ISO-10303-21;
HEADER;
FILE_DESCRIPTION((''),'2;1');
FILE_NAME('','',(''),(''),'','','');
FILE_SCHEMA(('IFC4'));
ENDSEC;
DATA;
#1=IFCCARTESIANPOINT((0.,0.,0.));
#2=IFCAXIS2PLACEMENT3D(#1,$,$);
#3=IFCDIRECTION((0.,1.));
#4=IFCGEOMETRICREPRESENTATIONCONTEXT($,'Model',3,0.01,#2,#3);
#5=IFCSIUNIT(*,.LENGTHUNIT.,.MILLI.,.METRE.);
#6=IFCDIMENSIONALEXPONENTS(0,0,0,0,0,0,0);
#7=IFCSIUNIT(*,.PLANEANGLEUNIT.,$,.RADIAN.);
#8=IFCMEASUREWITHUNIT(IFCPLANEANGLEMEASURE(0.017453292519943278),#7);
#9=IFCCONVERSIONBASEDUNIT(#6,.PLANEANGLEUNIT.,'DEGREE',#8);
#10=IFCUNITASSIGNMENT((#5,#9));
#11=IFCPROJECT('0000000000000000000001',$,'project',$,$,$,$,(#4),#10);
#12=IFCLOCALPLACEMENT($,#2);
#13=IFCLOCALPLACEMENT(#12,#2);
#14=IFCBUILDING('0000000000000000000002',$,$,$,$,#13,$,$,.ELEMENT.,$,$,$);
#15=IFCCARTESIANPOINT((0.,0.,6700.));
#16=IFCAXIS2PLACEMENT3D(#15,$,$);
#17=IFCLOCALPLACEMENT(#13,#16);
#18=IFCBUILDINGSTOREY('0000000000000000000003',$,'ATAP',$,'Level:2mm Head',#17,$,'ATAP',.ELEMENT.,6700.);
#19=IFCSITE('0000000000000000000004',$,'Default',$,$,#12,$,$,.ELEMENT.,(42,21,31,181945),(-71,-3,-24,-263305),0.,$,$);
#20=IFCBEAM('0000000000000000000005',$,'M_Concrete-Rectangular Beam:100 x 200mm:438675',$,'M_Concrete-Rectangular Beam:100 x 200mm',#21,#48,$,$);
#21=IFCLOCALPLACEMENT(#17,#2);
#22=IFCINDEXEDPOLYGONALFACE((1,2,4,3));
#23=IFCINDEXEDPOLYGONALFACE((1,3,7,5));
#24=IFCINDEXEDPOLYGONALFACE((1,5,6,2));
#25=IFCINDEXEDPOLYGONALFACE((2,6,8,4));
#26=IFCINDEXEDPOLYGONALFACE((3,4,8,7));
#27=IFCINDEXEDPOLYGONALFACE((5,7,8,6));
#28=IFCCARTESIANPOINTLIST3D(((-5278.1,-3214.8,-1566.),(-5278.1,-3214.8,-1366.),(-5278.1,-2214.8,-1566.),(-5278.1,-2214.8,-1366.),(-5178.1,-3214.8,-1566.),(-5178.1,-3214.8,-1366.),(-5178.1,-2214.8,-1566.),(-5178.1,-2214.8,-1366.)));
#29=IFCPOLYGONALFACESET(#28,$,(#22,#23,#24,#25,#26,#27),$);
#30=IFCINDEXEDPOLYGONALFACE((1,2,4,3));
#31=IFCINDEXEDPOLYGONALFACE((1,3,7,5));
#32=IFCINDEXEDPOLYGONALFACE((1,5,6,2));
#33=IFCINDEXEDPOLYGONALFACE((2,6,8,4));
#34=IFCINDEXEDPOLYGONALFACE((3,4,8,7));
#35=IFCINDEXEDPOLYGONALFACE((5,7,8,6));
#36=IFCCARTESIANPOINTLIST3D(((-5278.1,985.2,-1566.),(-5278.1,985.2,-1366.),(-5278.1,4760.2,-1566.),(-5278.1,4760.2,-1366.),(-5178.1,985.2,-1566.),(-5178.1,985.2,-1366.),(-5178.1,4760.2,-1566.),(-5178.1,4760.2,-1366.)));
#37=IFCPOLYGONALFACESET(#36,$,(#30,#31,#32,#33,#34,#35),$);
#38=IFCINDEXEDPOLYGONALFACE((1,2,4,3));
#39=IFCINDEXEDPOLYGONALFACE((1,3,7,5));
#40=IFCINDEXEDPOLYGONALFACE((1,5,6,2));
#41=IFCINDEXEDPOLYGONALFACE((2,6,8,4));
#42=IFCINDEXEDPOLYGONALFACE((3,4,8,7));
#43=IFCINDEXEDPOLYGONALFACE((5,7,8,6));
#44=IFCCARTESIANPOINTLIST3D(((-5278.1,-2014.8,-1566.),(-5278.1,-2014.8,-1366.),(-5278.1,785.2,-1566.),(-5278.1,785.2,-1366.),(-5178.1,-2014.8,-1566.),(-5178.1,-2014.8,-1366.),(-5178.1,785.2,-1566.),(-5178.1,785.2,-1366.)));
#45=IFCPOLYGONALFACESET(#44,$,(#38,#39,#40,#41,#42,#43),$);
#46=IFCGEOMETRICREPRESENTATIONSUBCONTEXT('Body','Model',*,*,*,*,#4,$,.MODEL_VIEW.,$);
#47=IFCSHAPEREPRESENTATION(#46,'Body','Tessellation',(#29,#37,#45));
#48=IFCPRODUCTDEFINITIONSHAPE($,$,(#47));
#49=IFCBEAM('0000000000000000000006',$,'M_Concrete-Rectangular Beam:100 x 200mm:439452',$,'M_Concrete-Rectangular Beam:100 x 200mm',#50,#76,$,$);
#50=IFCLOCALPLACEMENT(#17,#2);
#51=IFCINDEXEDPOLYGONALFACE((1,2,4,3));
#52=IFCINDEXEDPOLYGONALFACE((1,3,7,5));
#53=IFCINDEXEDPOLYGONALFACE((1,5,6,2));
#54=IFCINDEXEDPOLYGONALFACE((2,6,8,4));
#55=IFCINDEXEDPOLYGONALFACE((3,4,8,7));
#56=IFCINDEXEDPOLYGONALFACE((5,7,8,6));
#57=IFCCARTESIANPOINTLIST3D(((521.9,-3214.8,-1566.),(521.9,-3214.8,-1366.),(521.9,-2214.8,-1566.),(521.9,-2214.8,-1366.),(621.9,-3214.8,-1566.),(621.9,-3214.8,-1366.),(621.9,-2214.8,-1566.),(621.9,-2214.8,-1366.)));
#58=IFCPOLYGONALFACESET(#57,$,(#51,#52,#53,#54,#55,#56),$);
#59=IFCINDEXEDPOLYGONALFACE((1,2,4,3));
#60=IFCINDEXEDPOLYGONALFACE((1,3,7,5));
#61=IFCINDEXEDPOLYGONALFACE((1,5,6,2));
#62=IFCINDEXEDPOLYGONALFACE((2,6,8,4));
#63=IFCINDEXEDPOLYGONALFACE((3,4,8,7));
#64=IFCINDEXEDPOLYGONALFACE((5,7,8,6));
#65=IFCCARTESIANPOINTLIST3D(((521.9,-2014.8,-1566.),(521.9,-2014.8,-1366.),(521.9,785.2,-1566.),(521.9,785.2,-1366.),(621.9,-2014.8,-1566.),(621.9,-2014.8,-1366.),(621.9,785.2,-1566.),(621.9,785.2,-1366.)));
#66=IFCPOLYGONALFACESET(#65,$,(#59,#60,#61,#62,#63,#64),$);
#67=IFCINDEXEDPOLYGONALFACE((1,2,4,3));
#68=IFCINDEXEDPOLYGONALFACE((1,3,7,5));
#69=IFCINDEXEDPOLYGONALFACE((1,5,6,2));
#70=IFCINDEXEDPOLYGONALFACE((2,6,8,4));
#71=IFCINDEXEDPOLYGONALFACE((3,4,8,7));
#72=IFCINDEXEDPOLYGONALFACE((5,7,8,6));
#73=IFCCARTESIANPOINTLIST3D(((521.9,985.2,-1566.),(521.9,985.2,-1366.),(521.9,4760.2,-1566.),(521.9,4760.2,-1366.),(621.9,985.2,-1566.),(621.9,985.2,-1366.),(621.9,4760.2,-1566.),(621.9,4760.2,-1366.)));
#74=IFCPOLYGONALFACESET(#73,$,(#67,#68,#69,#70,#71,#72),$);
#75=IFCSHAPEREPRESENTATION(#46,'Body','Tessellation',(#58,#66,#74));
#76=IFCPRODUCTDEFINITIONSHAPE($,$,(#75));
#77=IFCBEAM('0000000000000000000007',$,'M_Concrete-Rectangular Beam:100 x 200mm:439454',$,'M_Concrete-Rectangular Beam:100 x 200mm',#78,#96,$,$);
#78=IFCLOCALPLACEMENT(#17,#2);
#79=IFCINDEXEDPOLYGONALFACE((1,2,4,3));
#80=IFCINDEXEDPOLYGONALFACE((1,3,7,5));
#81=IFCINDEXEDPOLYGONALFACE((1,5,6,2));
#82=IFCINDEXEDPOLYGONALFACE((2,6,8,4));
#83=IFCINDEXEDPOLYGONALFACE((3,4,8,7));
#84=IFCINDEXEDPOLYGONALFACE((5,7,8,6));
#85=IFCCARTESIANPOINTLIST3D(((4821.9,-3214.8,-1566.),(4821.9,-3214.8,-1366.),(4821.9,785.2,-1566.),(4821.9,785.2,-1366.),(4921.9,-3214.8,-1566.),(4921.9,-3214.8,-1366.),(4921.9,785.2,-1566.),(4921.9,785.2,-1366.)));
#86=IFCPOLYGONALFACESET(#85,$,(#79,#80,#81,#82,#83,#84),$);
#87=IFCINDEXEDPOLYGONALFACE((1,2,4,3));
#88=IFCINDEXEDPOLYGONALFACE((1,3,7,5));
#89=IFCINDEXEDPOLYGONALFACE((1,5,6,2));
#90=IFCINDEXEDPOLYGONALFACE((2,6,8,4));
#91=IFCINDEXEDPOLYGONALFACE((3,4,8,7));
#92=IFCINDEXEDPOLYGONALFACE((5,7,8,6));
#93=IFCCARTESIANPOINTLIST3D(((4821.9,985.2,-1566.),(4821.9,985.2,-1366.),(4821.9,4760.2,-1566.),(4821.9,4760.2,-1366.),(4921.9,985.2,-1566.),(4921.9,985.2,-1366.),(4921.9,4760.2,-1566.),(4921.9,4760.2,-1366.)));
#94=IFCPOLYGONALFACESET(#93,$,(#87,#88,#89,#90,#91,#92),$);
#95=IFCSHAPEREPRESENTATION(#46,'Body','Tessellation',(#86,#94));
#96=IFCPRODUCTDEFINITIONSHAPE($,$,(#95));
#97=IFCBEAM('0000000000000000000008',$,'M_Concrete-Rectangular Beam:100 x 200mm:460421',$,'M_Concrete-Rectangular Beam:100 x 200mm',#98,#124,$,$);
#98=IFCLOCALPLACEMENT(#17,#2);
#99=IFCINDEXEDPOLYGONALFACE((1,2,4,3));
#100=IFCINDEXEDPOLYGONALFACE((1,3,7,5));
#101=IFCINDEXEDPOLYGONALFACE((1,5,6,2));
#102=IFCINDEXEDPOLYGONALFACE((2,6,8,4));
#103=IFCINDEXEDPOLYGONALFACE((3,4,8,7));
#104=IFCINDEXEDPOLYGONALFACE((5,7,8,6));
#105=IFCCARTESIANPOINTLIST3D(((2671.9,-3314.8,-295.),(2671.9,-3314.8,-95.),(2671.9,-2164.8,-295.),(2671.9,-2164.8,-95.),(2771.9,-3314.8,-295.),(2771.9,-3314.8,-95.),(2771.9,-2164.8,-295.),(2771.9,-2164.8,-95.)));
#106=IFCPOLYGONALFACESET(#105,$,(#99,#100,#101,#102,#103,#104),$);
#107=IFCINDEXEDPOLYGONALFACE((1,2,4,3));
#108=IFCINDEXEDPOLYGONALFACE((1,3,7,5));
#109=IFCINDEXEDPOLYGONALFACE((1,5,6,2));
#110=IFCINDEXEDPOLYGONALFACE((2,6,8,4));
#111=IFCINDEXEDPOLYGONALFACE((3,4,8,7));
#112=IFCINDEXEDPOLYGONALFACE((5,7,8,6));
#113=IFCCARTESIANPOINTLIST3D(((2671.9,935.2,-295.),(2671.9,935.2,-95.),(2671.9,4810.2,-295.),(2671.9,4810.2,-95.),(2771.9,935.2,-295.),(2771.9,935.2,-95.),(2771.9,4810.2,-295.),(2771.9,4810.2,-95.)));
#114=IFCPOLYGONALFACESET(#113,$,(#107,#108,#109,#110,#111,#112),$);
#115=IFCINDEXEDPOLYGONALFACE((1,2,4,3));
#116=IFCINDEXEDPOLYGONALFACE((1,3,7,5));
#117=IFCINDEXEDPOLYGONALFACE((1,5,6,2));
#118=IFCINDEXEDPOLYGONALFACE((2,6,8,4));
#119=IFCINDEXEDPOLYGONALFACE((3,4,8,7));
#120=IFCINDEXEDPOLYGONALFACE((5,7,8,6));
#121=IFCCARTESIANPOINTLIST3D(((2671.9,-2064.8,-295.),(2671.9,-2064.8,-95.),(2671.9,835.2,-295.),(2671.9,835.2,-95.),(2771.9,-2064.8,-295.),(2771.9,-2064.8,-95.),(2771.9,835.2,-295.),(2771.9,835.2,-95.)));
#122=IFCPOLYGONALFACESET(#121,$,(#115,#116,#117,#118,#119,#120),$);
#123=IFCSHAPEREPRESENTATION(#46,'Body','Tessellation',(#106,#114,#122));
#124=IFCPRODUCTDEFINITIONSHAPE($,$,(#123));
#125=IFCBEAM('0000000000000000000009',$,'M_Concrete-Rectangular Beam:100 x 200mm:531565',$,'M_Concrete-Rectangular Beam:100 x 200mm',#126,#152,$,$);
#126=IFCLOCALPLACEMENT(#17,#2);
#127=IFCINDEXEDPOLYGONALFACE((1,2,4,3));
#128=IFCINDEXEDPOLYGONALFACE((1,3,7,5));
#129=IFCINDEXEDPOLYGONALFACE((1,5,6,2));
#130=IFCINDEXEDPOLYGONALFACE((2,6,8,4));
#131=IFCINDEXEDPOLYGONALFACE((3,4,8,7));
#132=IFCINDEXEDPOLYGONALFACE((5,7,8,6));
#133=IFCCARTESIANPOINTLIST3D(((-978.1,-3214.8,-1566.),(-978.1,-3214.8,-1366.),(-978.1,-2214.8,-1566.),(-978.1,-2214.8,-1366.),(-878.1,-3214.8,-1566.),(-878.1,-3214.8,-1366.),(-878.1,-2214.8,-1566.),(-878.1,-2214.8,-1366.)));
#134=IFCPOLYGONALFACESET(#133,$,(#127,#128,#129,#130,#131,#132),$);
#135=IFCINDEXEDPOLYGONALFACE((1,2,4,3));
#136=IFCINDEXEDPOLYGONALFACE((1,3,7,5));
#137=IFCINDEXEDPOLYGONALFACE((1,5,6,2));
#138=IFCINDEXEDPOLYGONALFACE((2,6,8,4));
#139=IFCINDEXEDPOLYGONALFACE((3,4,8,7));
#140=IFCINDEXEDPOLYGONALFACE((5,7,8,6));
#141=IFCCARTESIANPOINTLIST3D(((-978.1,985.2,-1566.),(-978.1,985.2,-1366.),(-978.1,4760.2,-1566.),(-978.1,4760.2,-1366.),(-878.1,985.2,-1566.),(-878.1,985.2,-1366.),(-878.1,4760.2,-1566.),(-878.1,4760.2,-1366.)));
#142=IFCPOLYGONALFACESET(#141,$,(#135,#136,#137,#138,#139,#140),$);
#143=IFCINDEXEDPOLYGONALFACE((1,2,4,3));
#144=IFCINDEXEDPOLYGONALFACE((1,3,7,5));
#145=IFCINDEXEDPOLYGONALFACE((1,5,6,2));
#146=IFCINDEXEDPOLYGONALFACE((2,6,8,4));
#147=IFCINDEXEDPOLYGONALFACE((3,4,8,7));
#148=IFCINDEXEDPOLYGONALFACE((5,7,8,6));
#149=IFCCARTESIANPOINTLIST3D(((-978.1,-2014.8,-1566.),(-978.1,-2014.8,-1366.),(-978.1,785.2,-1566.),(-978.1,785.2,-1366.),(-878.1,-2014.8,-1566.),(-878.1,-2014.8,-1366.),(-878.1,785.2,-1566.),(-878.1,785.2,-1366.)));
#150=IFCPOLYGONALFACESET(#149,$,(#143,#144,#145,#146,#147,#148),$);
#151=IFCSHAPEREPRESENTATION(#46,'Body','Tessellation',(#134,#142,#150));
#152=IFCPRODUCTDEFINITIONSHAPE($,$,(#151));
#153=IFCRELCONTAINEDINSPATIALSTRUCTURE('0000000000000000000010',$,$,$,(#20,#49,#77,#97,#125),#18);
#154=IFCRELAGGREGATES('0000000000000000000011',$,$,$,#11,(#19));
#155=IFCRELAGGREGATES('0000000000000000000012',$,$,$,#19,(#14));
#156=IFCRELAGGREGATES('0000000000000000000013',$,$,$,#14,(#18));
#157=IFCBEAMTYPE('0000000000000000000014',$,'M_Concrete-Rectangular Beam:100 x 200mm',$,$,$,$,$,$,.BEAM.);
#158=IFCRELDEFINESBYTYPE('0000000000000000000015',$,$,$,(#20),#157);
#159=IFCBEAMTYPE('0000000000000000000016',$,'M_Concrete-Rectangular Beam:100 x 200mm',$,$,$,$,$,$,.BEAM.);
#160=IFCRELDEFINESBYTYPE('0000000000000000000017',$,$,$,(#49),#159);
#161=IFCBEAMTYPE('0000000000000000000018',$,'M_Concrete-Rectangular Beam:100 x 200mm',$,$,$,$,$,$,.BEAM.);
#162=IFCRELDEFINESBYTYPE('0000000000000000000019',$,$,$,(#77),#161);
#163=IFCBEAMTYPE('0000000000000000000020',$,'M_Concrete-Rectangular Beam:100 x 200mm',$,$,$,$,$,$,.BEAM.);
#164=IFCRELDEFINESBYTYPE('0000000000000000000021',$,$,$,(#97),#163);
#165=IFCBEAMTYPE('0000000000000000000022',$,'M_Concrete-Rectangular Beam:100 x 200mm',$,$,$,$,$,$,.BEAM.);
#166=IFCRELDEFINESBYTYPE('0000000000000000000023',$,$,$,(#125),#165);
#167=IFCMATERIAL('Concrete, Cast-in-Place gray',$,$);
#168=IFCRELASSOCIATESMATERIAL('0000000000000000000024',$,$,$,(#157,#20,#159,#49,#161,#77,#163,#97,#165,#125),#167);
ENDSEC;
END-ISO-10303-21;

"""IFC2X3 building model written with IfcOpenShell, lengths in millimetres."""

from ifc_helpers import new_model, entity, si_unit, converted_unit, direction, frame, frame_2d, origin, place, context, subcontext, project, spatial, rectangle, extrude, source, transform, mapped, material, type_object, type_shapes, element, save


model = new_model("IFC2X3")

# Units and contexts
model_context = context("Model", 3, precision=0.01, world=origin(), true_north=direction((0.0, 1.0)))
body_context = subcontext(model_context, "Body", "Model", "MODEL_VIEW")
ifc_project = project(units=[si_unit("LENGTHUNIT", "METRE", prefix="MILLI"), converted_unit("PLANEANGLEUNIT", "DEGREE", entity("IfcPlaneAngleMeasure", 0.017453292519943278), si_unit("PLANEANGLEUNIT", "RADIAN"), dimensions=[0, 0, 0, 0, 0, 0, 0])], contexts=[model_context])

# Site, building, storey
site_placement = place(None, origin())
site = spatial("IfcSite", under=ifc_project, at=site_placement, Name="Default", CompositionType="ELEMENT", RefLatitude=(42, 21, 31, 181945), RefLongitude=(-71, -3, -24, -263305), RefElevation=0.0)
building_placement = place(site_placement, origin())
building = spatial("IfcBuilding", under=site, at=building_placement, CompositionType="ELEMENT")
storey_placement = place(building_placement, frame((0.0, 0.0, 6700.0)))
storey = spatial("IfcBuildingStorey", under=building, at=storey_placement, Name="ATAP", ObjectType="Level:2mm Head", LongName="ATAP", CompositionType="ELEMENT", Elevation=6700.0)

# Beams
ifc_material = material(Name="Concrete, Cast-in-Place gray")
beam_type_1 = type_object("IfcBeamType", Name="M_Concrete-Rectangular Beam:100 x 200mm", PredefinedType="BEAM", material=ifc_material)
shared_shape_1 = source(origin(), body_context, "Body", "SweptSolid", [
    extrude(rectangle(XDim=200.0, YDim=100.0, at=frame_2d((0.0, 0.0), x_axis=(0.0, 1.0))), frame((-5228.1, -2214.8, 5234.0), z_axis=(0.0, -1.0, 0.0), x_axis=(-1.0, 0.0, 0.0)), (0.0, 0.0, 1.0), 1000.0),
    extrude(rectangle(XDim=200.0, YDim=100.0, at=frame_2d((0.0, 0.0), x_axis=(0.0, 1.0))), frame((-5228.1, 4760.2, 5234.0), z_axis=(0.0, -1.0, 0.0), x_axis=(-1.0, 0.0, 0.0)), (0.0, 0.0, 1.0), 3775.0),
    extrude(rectangle(XDim=200.0, YDim=100.0, at=frame_2d((0.0, 0.0), x_axis=(0.0, 1.0))), frame((-5228.1, 785.2, 5234.0), z_axis=(0.0, -1.0, 0.0), x_axis=(-1.0, 0.0, 0.0)), (0.0, 0.0, 1.0), 2800.0),
])
type_shapes(beam_type_1, [shared_shape_1])
beam_1_placement = place(storey_placement, frame((0.0, 0.0, -6700.0)))
element("IfcBeam", 1, at=beam_1_placement, inside=storey, type_object=beam_type_1, material=ifc_material, Name="M_Concrete-Rectangular Beam:100 x 200mm:438675", ObjectType="M_Concrete-Rectangular Beam:100 x 200mm", context=body_context, shape_type="MappedRepresentation", body=[
    mapped(shared_shape_1, transform((0.0, 0.0, 0.0), scale=1.0)),
])
beam_type_2 = type_object("IfcBeamType", Name="M_Concrete-Rectangular Beam:100 x 200mm", PredefinedType="BEAM", material=ifc_material)
shared_shape_2 = source(origin(), body_context, "Body", "SweptSolid", [
    extrude(rectangle(XDim=200.0, YDim=100.0, at=frame_2d((0.0, 0.0), x_axis=(0.0, 1.0))), frame((571.9, -2214.8, 5234.0), z_axis=(0.0, -1.0, 0.0), x_axis=(-1.0, 0.0, 0.0)), (0.0, 0.0, 1.0), 1000.0),
    extrude(rectangle(XDim=200.0, YDim=100.0, at=frame_2d((0.0, 0.0), x_axis=(0.0, 1.0))), frame((571.9, 785.2, 5234.0), z_axis=(0.0, -1.0, 0.0), x_axis=(-1.0, 0.0, 0.0)), (0.0, 0.0, 1.0), 2800.0),
    extrude(rectangle(XDim=200.0, YDim=100.0, at=frame_2d((0.0, 0.0), x_axis=(0.0, 1.0))), frame((571.9, 4760.2, 5234.0), z_axis=(0.0, -1.0, 0.0), x_axis=(-1.0, 0.0, 0.0)), (0.0, 0.0, 1.0), 3775.0),
])
type_shapes(beam_type_2, [shared_shape_2])
beam_2_placement = place(storey_placement, frame((0.0, 0.0, -6700.0)))
element("IfcBeam", 2, at=beam_2_placement, inside=storey, type_object=beam_type_2, material=ifc_material, Name="M_Concrete-Rectangular Beam:100 x 200mm:439452", ObjectType="M_Concrete-Rectangular Beam:100 x 200mm", context=body_context, shape_type="MappedRepresentation", body=[
    mapped(shared_shape_2, transform((0.0, 0.0, 0.0), scale=1.0)),
])
beam_type_3 = type_object("IfcBeamType", Name="M_Concrete-Rectangular Beam:100 x 200mm", PredefinedType="BEAM", material=ifc_material)
shared_shape_3 = source(origin(), body_context, "Body", "SweptSolid", [
    extrude(rectangle(XDim=200.0, YDim=100.0, at=frame_2d((0.0, 0.0), x_axis=(0.0, 1.0))), frame((4871.9, 785.2, 5234.0), z_axis=(0.0, -1.0, 0.0), x_axis=(-1.0, 0.0, 0.0)), (0.0, 0.0, 1.0), 4000.0),
    extrude(rectangle(XDim=200.0, YDim=100.0, at=frame_2d((0.0, 0.0), x_axis=(0.0, 1.0))), frame((4871.9, 4760.2, 5234.0), z_axis=(0.0, -1.0, 0.0), x_axis=(-1.0, 0.0, 0.0)), (0.0, 0.0, 1.0), 3775.0),
])
type_shapes(beam_type_3, [shared_shape_3])
beam_3_placement = place(storey_placement, frame((0.0, 0.0, -6700.0)))
element("IfcBeam", 3, at=beam_3_placement, inside=storey, type_object=beam_type_3, material=ifc_material, Name="M_Concrete-Rectangular Beam:100 x 200mm:439454", ObjectType="M_Concrete-Rectangular Beam:100 x 200mm", context=body_context, shape_type="MappedRepresentation", body=[
    mapped(shared_shape_3, transform((0.0, 0.0, 0.0), scale=1.0)),
])
beam_type_4 = type_object("IfcBeamType", Name="M_Concrete-Rectangular Beam:100 x 200mm", PredefinedType="BEAM", material=ifc_material)
shared_shape_4 = source(origin(), body_context, "Body", "SweptSolid", [
    extrude(rectangle(XDim=200.0, YDim=100.0, at=frame_2d((0.0, 0.0), x_axis=(0.0, 1.0))), frame((2721.9, -3314.8, 6505.0), z_axis=(0.0, 1.0, 0.0), x_axis=(-1.0, 0.0, 0.0)), (0.0, 0.0, 1.0), 1150.0),
    extrude(rectangle(XDim=200.0, YDim=100.0, at=frame_2d((0.0, 0.0), x_axis=(0.0, 1.0))), frame((2721.9, 935.2, 6505.0), z_axis=(0.0, 1.0, 0.0), x_axis=(-1.0, 0.0, 0.0)), (0.0, 0.0, 1.0), 3875.0),
    extrude(rectangle(XDim=200.0, YDim=100.0, at=frame_2d((0.0, 0.0), x_axis=(0.0, 1.0))), frame((2721.9, -2064.8, 6505.0), z_axis=(0.0, 1.0, 0.0), x_axis=(-1.0, 0.0, 0.0)), (0.0, 0.0, 1.0), 2900.0),
])
type_shapes(beam_type_4, [shared_shape_4])
beam_4_placement = place(storey_placement, frame((0.0, 0.0, -6700.0)))
element("IfcBeam", 4, at=beam_4_placement, inside=storey, type_object=beam_type_4, material=ifc_material, Name="M_Concrete-Rectangular Beam:100 x 200mm:460421", ObjectType="M_Concrete-Rectangular Beam:100 x 200mm", context=body_context, shape_type="MappedRepresentation", body=[
    mapped(shared_shape_4, transform((0.0, 0.0, 0.0), scale=1.0)),
])
beam_type_5 = type_object("IfcBeamType", Name="M_Concrete-Rectangular Beam:100 x 200mm", PredefinedType="BEAM", material=ifc_material)
shared_shape_5 = source(origin(), body_context, "Body", "SweptSolid", [
    extrude(rectangle(XDim=200.0, YDim=100.0, at=frame_2d((0.0, 0.0), x_axis=(0.0, 1.0))), frame((-928.1, -2214.8, 5234.0), z_axis=(0.0, -1.0, 0.0), x_axis=(-1.0, 0.0, 0.0)), (0.0, 0.0, 1.0), 1000.0),
    extrude(rectangle(XDim=200.0, YDim=100.0, at=frame_2d((0.0, 0.0), x_axis=(0.0, 1.0))), frame((-928.1, 4760.2, 5234.0), z_axis=(0.0, -1.0, 0.0), x_axis=(-1.0, 0.0, 0.0)), (0.0, 0.0, 1.0), 3775.0),
    extrude(rectangle(XDim=200.0, YDim=100.0, at=frame_2d((0.0, 0.0), x_axis=(0.0, 1.0))), frame((-928.1, 785.2, 5234.0), z_axis=(0.0, -1.0, 0.0), x_axis=(-1.0, 0.0, 0.0)), (0.0, 0.0, 1.0), 2800.0),
])
type_shapes(beam_type_5, [shared_shape_5])
beam_5_placement = place(storey_placement, frame((0.0, 0.0, -6700.0)))
element("IfcBeam", 5, at=beam_5_placement, inside=storey, type_object=beam_type_5, material=ifc_material, Name="M_Concrete-Rectangular Beam:100 x 200mm:531565", ObjectType="M_Concrete-Rectangular Beam:100 x 200mm", context=body_context, shape_type="MappedRepresentation", body=[
    mapped(shared_shape_5, transform((0.0, 0.0, 0.0), scale=1.0)),
])

save(model, "model.ifc")
